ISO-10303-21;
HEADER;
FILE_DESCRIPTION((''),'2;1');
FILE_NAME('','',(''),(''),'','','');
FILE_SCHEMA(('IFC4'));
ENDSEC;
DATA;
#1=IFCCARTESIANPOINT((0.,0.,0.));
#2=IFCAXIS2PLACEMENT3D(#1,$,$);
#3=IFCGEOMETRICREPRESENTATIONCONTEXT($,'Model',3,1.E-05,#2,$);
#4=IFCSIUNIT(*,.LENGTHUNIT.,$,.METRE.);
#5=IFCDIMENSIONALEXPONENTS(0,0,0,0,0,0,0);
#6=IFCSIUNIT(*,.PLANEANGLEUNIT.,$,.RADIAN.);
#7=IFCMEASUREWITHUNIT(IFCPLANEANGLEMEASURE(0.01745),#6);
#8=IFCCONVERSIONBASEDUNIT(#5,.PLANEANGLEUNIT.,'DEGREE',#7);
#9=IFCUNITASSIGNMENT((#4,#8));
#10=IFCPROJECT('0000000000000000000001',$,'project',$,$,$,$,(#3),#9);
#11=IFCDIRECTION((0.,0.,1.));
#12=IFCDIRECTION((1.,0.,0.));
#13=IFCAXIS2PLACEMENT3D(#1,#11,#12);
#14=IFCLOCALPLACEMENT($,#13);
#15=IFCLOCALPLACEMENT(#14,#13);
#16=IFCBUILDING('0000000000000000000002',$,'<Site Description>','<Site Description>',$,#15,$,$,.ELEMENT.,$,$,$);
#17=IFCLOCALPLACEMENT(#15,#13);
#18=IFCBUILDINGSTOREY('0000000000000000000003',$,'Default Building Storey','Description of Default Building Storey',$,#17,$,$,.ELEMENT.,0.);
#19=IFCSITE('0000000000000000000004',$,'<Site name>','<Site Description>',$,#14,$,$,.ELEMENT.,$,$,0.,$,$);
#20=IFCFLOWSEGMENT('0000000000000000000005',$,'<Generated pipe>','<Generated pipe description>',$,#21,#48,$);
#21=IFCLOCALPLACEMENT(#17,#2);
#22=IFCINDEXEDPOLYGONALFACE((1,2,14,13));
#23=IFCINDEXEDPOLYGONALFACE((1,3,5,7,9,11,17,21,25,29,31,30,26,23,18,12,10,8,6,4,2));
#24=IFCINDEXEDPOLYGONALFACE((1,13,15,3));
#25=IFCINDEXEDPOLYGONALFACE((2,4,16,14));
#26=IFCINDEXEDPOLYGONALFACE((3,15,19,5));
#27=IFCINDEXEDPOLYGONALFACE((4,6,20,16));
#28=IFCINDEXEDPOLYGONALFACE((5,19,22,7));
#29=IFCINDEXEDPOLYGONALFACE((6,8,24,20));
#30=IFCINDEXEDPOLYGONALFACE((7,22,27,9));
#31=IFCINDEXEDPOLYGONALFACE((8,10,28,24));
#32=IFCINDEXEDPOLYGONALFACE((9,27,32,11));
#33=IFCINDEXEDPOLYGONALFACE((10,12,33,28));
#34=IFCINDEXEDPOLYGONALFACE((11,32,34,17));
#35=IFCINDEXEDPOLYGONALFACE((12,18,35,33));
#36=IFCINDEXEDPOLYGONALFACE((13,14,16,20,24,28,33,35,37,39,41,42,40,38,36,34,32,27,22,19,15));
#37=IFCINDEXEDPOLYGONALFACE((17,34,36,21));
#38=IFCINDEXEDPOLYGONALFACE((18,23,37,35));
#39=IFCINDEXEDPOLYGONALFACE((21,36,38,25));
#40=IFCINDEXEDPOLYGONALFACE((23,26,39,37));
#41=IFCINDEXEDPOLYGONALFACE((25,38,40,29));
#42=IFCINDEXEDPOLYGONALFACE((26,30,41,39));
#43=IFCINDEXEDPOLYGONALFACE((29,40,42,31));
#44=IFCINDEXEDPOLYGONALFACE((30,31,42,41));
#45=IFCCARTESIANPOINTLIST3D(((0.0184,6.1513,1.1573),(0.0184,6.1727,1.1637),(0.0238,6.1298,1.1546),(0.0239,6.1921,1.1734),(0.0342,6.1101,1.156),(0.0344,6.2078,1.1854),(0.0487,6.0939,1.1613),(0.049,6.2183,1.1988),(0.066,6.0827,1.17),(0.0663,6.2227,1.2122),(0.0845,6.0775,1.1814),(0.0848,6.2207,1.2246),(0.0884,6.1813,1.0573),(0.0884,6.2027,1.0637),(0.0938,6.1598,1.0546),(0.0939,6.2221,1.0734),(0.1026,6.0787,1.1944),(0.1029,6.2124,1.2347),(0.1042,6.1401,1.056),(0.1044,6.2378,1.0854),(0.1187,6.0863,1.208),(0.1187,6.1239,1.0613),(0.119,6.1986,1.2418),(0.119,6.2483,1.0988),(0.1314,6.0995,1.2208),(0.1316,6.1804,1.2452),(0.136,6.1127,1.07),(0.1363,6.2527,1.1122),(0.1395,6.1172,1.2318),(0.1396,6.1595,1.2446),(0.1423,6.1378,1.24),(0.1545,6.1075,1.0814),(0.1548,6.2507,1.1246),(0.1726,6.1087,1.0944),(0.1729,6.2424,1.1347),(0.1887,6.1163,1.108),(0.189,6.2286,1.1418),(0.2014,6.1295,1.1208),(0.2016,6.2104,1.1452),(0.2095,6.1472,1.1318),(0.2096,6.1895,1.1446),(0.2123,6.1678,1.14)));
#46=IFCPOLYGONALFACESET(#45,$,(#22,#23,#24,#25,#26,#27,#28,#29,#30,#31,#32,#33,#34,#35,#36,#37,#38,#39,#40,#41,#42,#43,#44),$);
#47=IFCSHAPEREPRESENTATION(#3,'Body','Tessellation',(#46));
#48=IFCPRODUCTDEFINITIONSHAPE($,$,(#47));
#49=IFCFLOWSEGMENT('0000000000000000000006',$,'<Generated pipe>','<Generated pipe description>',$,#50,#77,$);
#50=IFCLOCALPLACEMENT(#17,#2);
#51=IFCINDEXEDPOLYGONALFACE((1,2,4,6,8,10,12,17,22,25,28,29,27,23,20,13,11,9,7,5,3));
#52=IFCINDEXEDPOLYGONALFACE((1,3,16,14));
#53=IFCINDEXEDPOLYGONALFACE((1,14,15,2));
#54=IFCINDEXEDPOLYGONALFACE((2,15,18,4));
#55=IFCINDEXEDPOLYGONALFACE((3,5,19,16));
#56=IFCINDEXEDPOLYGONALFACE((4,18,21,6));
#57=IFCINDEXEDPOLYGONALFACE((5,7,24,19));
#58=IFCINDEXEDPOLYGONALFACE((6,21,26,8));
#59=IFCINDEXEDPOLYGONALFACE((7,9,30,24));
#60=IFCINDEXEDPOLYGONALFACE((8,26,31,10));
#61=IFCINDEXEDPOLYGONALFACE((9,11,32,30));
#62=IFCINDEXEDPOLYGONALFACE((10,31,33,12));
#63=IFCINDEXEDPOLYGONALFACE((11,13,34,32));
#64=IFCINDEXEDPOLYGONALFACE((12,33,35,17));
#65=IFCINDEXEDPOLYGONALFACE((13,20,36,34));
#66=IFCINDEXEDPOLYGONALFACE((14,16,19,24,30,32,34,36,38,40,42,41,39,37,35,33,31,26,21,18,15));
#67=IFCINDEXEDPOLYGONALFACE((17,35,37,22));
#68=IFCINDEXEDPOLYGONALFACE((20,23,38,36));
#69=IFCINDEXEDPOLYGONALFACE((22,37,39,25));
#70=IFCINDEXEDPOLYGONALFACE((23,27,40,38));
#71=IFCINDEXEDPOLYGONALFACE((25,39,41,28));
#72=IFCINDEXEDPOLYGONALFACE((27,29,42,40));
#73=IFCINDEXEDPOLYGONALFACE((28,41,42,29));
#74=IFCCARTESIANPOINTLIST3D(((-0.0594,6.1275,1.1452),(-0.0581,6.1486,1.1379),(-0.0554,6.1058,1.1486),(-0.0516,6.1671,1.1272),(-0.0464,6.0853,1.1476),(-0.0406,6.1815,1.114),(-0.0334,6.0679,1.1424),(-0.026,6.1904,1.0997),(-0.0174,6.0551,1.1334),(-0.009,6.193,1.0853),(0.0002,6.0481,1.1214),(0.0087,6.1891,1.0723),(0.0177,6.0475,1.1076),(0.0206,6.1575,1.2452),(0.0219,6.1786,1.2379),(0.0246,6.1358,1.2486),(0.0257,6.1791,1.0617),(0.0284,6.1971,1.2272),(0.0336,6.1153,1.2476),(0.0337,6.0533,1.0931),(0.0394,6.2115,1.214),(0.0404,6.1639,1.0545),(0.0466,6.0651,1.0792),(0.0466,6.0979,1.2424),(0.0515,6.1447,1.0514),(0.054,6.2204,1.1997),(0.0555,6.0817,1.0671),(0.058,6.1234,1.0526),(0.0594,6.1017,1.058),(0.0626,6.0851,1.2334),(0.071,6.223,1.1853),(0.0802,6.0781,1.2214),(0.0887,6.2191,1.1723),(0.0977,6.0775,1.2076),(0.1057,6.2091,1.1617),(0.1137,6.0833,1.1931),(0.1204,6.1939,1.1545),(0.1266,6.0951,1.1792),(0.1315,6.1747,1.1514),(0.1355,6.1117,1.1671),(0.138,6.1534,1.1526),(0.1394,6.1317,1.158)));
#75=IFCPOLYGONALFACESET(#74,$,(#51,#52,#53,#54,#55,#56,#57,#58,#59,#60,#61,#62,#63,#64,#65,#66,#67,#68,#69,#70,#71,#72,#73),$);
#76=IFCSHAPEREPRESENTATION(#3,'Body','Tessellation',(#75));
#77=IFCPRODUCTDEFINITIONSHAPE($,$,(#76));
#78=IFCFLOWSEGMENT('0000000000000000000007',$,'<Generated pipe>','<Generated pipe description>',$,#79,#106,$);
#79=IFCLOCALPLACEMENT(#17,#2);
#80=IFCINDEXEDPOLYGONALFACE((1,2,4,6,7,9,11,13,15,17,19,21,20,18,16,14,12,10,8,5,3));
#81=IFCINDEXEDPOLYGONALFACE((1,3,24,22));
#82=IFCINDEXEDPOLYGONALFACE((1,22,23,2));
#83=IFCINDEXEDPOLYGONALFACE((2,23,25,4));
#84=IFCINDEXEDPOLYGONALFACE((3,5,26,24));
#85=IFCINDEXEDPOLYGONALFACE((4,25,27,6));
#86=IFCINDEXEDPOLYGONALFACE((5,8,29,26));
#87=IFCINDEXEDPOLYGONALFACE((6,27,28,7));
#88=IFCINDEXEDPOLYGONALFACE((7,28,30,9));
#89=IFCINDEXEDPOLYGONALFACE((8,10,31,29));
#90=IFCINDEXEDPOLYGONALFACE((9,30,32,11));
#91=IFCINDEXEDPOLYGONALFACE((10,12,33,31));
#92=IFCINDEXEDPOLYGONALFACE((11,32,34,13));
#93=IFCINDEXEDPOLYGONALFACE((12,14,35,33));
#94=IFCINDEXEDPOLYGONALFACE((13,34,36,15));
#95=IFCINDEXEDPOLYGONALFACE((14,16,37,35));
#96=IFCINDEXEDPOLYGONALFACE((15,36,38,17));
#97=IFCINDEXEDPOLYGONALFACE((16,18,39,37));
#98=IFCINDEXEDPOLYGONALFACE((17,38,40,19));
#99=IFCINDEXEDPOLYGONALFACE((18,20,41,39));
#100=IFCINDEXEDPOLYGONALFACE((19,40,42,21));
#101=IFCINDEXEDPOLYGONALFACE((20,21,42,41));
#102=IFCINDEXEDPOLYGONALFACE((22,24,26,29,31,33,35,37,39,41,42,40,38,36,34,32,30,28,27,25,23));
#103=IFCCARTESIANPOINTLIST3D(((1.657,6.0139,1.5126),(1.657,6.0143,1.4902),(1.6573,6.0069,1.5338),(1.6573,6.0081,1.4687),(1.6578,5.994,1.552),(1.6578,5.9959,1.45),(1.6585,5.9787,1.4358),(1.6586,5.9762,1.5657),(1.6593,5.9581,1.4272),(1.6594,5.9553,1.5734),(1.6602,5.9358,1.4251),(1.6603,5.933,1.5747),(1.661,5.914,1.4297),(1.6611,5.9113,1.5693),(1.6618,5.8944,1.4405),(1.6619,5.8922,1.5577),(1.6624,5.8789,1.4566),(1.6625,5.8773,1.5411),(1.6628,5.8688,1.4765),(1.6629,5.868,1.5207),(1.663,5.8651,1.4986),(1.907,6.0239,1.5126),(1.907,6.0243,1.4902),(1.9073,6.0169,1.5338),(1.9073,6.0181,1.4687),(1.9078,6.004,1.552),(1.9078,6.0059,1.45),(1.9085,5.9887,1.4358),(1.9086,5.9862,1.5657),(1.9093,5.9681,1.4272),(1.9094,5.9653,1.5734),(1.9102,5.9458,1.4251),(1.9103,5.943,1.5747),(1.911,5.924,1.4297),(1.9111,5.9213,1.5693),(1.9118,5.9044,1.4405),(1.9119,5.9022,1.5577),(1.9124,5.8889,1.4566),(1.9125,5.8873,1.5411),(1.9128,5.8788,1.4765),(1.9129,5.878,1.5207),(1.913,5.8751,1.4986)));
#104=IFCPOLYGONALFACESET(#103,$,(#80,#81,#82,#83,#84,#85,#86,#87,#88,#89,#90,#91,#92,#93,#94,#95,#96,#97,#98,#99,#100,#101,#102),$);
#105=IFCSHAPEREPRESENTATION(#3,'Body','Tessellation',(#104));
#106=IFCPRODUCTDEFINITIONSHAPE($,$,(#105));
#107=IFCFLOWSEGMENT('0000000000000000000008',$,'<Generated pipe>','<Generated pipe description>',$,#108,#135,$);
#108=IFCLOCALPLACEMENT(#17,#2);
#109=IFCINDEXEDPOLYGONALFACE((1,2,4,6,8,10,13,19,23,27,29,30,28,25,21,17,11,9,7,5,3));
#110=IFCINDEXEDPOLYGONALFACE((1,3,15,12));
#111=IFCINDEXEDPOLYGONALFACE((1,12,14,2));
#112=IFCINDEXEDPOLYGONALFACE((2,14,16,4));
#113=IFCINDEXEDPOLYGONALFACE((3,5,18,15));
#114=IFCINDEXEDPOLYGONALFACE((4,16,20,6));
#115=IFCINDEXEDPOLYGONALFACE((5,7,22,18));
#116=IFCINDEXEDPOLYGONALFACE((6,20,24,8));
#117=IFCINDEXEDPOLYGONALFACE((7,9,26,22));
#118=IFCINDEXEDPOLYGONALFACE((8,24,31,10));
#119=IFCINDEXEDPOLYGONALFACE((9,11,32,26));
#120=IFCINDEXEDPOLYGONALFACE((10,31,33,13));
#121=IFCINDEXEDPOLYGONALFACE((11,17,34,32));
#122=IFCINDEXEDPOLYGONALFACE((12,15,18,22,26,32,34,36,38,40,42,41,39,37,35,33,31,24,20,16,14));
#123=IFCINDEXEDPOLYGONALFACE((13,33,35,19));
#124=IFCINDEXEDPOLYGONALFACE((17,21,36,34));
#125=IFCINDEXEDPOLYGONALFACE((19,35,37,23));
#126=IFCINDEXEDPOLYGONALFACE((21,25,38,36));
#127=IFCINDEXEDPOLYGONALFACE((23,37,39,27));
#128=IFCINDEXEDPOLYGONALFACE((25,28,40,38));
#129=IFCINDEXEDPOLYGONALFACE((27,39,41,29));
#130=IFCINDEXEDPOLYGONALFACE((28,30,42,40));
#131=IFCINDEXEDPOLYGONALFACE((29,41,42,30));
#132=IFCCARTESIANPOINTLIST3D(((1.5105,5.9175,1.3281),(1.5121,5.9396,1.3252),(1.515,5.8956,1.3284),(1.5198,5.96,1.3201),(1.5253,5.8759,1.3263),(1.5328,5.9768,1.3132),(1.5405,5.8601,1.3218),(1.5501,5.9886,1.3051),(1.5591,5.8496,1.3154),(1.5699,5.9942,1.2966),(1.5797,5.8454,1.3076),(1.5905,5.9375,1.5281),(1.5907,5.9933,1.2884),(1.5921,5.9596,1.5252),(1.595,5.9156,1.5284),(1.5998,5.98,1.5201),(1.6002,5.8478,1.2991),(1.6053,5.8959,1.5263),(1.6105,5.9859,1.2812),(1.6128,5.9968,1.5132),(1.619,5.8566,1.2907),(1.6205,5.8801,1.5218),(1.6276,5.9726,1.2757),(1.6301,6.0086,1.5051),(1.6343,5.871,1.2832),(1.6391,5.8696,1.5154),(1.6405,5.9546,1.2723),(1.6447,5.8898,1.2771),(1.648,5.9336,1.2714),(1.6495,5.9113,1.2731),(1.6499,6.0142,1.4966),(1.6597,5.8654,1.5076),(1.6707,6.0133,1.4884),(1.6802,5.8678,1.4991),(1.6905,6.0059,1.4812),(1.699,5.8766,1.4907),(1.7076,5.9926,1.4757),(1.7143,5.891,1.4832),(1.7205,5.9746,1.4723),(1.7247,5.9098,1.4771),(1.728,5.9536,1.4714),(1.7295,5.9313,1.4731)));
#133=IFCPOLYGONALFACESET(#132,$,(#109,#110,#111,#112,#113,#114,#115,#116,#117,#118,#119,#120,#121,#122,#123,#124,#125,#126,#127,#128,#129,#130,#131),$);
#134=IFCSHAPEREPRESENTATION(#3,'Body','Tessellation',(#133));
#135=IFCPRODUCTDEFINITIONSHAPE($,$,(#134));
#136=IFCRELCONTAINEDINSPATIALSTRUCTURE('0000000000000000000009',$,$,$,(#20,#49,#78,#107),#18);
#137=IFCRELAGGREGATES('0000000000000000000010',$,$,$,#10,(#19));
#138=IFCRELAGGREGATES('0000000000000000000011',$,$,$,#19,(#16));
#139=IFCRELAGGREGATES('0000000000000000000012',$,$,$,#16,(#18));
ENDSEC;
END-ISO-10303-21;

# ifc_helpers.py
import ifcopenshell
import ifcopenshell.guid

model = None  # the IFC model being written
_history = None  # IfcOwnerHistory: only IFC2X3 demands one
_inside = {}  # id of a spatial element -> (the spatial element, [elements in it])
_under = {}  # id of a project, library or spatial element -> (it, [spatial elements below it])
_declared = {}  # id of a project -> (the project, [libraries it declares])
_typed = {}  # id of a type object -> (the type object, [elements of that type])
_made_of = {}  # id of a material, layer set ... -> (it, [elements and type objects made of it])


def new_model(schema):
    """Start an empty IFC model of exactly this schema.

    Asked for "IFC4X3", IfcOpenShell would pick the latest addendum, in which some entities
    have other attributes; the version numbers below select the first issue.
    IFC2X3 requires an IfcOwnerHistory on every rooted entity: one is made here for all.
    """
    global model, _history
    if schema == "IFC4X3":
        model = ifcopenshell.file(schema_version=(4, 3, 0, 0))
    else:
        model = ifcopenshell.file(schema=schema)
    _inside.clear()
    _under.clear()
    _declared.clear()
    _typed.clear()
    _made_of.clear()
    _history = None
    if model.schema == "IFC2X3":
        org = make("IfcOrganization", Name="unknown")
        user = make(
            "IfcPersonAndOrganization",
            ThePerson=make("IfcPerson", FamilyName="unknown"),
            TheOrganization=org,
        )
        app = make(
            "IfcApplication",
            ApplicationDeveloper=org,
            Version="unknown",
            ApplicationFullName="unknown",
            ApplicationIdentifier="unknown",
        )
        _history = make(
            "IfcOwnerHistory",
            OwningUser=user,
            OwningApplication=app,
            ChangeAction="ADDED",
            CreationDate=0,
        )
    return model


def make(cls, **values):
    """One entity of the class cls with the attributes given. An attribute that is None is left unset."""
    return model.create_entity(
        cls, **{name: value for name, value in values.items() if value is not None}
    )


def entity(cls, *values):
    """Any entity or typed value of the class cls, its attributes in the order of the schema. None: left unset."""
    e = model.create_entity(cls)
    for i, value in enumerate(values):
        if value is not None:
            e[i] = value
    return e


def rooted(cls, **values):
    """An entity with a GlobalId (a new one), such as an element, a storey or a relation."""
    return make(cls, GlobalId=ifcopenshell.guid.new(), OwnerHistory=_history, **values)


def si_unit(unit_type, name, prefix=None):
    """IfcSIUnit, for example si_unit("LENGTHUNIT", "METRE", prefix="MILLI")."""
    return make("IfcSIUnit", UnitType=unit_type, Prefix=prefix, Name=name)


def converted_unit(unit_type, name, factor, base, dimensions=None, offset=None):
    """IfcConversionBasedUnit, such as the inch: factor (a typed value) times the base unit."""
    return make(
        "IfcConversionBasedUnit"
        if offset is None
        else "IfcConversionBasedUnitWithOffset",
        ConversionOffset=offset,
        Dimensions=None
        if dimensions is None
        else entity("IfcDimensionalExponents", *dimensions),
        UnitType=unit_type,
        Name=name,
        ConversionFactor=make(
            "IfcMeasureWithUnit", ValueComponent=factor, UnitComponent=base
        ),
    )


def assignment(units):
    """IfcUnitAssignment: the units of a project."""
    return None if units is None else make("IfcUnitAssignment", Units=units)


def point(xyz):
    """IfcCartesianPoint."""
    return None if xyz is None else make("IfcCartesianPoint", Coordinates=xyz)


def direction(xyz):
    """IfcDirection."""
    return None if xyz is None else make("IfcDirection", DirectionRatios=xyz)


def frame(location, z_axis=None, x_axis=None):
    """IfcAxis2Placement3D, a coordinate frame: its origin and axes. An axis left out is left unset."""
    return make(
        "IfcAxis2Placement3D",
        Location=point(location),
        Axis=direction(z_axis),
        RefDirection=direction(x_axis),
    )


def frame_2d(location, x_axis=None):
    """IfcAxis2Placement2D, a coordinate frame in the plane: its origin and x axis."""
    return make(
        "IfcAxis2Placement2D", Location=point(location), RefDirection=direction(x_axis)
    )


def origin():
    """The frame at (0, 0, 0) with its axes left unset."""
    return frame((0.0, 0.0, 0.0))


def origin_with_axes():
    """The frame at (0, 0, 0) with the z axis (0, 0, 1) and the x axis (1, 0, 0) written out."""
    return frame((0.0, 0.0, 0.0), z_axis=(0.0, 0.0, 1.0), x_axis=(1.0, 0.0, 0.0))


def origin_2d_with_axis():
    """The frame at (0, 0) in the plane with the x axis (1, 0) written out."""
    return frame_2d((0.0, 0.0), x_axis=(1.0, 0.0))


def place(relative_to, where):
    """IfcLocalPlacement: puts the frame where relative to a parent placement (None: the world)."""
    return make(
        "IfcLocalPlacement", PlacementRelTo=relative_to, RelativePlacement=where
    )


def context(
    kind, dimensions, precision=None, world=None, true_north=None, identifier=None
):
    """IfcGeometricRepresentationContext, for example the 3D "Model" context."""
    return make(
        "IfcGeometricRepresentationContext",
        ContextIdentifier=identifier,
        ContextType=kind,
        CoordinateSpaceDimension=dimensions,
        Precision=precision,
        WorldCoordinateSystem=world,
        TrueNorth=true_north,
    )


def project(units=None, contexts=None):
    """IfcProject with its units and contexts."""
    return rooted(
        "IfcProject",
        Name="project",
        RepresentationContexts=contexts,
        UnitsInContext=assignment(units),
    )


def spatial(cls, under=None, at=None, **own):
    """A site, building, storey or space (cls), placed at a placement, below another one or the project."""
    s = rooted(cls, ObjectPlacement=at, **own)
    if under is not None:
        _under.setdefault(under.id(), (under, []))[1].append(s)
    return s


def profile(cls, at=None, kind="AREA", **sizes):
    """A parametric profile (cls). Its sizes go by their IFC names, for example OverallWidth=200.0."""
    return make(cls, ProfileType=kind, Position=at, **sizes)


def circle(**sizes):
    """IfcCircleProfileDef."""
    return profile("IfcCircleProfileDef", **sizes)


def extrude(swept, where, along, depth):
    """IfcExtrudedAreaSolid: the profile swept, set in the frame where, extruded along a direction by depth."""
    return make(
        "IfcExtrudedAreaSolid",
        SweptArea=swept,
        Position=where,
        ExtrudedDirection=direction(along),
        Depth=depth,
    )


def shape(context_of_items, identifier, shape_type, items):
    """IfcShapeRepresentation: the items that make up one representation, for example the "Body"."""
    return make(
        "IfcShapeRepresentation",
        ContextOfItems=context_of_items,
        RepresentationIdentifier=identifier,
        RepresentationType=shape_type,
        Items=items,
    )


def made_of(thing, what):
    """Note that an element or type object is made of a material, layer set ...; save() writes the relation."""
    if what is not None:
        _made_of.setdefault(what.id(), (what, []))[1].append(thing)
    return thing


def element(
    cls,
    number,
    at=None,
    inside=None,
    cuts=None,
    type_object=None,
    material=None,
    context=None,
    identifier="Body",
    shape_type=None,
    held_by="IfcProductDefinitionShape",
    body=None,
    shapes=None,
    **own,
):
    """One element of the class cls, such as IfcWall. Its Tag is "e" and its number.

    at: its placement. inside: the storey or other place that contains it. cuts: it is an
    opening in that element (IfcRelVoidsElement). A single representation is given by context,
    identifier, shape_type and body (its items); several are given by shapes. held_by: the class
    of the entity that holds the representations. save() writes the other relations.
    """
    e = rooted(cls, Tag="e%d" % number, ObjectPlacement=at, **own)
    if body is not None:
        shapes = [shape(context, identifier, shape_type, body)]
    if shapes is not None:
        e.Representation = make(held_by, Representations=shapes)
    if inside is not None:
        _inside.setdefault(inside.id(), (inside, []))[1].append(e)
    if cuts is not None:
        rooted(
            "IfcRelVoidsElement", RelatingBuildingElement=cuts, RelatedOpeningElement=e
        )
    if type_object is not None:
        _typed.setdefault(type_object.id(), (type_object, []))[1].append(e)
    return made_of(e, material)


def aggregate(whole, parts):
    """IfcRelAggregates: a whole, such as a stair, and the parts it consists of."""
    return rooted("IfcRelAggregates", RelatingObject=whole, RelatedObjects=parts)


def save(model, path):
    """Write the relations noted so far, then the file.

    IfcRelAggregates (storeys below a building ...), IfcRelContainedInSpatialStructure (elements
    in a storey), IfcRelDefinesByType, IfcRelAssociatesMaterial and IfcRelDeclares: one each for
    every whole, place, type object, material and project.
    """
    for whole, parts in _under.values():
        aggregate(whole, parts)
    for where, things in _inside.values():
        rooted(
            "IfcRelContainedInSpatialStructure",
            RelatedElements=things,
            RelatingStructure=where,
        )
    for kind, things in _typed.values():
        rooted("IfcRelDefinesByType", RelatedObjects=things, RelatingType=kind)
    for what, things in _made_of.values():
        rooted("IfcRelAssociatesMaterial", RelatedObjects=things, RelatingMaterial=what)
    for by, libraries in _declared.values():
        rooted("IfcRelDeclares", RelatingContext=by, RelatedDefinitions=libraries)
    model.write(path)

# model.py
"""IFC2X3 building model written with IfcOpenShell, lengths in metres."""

from ifc_helpers import new_model, entity, si_unit, converted_unit, frame, origin, origin_with_axes, origin_2d_with_axis, place, context, project, spatial, circle, extrude, element, save


model = new_model("IFC2X3")

# Units and contexts
model_context = context("Model", 3, precision=1e-05, world=origin())
ifc_project = project(units=[si_unit("LENGTHUNIT", "METRE"), converted_unit("PLANEANGLEUNIT", "DEGREE", entity("IfcPlaneAngleMeasure", 0.01745), si_unit("PLANEANGLEUNIT", "RADIAN"), dimensions=[0, 0, 0, 0, 0, 0, 0])], contexts=[model_context])

# Site, building, storey
site_placement = place(None, origin_with_axes())
site = spatial("IfcSite", under=ifc_project, at=site_placement, Name="<Site name>", Description="<Site Description>", CompositionType="ELEMENT", RefElevation=0.0)
building_placement = place(site_placement, origin_with_axes())
building = spatial("IfcBuilding", under=site, at=building_placement, Name="<Site Description>", Description="<Site Description>", CompositionType="ELEMENT")
storey_placement = place(building_placement, origin_with_axes())
storey = spatial("IfcBuildingStorey", under=building, at=storey_placement, Name="Default Building Storey", Description="Description of Default Building Storey", CompositionType="ELEMENT", Elevation=0.0)

# Flow segments
flow_segment_1_placement = place(storey_placement, frame((0.15, 6.18, 1.1), z_axis=(-0.55689, -0.238667, 0.795557), x_axis=(0.687379, 0.405239, 0.602737)))
element("IfcFlowSegment", 1, at=flow_segment_1_placement, inside=storey, Name="<Generated pipe>", Description="<Generated pipe description>", context=model_context, shape_type="SweptSolid", body=[
    extrude(circle(Radius=0.075, at=origin_2d_with_axis()), origin_with_axes(), (0.0, 0.0, 1.0), 0.1257),
])
flow_segment_2_placement = place(storey_placement, frame((0.08, 6.15, 1.2), z_axis=(-0.608229, -0.228086, -0.760286), x_axis=(0.538359, 0.585314, -0.606281)))
element("IfcFlowSegment", 2, at=flow_segment_2_placement, inside=storey, Name="<Generated pipe>", Description="<Generated pipe description>", context=model_context, shape_type="SweptSolid", body=[
    extrude(circle(Radius=0.075, at=origin_2d_with_axis()), origin_with_axes(), (0.0, 0.0, 1.0), 0.1315),
])
flow_segment_3_placement = place(storey_placement, frame((1.91, 5.95, 1.5), z_axis=(-0.999201, -0.039968, 0.0), x_axis=(-0.039401, 0.985035, 0.16779)))
element("IfcFlowSegment", 3, at=flow_segment_3_placement, inside=storey, Name="<Generated pipe>", Description="<Generated pipe description>", context=model_context, shape_type="SweptSolid", body=[
    extrude(circle(Radius=0.075, at=origin_2d_with_axis()), origin_with_axes(), (0.0, 0.0, 1.0), 0.2502),
])
flow_segment_4_placement = place(storey_placement, frame((1.66, 5.94, 1.5), z_axis=(-0.3698, -0.09245, -0.9245), x_axis=(0.142846, 0.97755, -0.154893)))
element("IfcFlowSegment", 4, at=flow_segment_4_placement, inside=storey, Name="<Generated pipe>", Description="<Generated pipe description>", context=model_context, shape_type="SweptSolid", body=[
    extrude(circle(Radius=0.075, at=origin_2d_with_axis()), origin_with_axes(), (0.0, 0.0, 1.0), 0.2163),
])

save(model, "model.ifc")
